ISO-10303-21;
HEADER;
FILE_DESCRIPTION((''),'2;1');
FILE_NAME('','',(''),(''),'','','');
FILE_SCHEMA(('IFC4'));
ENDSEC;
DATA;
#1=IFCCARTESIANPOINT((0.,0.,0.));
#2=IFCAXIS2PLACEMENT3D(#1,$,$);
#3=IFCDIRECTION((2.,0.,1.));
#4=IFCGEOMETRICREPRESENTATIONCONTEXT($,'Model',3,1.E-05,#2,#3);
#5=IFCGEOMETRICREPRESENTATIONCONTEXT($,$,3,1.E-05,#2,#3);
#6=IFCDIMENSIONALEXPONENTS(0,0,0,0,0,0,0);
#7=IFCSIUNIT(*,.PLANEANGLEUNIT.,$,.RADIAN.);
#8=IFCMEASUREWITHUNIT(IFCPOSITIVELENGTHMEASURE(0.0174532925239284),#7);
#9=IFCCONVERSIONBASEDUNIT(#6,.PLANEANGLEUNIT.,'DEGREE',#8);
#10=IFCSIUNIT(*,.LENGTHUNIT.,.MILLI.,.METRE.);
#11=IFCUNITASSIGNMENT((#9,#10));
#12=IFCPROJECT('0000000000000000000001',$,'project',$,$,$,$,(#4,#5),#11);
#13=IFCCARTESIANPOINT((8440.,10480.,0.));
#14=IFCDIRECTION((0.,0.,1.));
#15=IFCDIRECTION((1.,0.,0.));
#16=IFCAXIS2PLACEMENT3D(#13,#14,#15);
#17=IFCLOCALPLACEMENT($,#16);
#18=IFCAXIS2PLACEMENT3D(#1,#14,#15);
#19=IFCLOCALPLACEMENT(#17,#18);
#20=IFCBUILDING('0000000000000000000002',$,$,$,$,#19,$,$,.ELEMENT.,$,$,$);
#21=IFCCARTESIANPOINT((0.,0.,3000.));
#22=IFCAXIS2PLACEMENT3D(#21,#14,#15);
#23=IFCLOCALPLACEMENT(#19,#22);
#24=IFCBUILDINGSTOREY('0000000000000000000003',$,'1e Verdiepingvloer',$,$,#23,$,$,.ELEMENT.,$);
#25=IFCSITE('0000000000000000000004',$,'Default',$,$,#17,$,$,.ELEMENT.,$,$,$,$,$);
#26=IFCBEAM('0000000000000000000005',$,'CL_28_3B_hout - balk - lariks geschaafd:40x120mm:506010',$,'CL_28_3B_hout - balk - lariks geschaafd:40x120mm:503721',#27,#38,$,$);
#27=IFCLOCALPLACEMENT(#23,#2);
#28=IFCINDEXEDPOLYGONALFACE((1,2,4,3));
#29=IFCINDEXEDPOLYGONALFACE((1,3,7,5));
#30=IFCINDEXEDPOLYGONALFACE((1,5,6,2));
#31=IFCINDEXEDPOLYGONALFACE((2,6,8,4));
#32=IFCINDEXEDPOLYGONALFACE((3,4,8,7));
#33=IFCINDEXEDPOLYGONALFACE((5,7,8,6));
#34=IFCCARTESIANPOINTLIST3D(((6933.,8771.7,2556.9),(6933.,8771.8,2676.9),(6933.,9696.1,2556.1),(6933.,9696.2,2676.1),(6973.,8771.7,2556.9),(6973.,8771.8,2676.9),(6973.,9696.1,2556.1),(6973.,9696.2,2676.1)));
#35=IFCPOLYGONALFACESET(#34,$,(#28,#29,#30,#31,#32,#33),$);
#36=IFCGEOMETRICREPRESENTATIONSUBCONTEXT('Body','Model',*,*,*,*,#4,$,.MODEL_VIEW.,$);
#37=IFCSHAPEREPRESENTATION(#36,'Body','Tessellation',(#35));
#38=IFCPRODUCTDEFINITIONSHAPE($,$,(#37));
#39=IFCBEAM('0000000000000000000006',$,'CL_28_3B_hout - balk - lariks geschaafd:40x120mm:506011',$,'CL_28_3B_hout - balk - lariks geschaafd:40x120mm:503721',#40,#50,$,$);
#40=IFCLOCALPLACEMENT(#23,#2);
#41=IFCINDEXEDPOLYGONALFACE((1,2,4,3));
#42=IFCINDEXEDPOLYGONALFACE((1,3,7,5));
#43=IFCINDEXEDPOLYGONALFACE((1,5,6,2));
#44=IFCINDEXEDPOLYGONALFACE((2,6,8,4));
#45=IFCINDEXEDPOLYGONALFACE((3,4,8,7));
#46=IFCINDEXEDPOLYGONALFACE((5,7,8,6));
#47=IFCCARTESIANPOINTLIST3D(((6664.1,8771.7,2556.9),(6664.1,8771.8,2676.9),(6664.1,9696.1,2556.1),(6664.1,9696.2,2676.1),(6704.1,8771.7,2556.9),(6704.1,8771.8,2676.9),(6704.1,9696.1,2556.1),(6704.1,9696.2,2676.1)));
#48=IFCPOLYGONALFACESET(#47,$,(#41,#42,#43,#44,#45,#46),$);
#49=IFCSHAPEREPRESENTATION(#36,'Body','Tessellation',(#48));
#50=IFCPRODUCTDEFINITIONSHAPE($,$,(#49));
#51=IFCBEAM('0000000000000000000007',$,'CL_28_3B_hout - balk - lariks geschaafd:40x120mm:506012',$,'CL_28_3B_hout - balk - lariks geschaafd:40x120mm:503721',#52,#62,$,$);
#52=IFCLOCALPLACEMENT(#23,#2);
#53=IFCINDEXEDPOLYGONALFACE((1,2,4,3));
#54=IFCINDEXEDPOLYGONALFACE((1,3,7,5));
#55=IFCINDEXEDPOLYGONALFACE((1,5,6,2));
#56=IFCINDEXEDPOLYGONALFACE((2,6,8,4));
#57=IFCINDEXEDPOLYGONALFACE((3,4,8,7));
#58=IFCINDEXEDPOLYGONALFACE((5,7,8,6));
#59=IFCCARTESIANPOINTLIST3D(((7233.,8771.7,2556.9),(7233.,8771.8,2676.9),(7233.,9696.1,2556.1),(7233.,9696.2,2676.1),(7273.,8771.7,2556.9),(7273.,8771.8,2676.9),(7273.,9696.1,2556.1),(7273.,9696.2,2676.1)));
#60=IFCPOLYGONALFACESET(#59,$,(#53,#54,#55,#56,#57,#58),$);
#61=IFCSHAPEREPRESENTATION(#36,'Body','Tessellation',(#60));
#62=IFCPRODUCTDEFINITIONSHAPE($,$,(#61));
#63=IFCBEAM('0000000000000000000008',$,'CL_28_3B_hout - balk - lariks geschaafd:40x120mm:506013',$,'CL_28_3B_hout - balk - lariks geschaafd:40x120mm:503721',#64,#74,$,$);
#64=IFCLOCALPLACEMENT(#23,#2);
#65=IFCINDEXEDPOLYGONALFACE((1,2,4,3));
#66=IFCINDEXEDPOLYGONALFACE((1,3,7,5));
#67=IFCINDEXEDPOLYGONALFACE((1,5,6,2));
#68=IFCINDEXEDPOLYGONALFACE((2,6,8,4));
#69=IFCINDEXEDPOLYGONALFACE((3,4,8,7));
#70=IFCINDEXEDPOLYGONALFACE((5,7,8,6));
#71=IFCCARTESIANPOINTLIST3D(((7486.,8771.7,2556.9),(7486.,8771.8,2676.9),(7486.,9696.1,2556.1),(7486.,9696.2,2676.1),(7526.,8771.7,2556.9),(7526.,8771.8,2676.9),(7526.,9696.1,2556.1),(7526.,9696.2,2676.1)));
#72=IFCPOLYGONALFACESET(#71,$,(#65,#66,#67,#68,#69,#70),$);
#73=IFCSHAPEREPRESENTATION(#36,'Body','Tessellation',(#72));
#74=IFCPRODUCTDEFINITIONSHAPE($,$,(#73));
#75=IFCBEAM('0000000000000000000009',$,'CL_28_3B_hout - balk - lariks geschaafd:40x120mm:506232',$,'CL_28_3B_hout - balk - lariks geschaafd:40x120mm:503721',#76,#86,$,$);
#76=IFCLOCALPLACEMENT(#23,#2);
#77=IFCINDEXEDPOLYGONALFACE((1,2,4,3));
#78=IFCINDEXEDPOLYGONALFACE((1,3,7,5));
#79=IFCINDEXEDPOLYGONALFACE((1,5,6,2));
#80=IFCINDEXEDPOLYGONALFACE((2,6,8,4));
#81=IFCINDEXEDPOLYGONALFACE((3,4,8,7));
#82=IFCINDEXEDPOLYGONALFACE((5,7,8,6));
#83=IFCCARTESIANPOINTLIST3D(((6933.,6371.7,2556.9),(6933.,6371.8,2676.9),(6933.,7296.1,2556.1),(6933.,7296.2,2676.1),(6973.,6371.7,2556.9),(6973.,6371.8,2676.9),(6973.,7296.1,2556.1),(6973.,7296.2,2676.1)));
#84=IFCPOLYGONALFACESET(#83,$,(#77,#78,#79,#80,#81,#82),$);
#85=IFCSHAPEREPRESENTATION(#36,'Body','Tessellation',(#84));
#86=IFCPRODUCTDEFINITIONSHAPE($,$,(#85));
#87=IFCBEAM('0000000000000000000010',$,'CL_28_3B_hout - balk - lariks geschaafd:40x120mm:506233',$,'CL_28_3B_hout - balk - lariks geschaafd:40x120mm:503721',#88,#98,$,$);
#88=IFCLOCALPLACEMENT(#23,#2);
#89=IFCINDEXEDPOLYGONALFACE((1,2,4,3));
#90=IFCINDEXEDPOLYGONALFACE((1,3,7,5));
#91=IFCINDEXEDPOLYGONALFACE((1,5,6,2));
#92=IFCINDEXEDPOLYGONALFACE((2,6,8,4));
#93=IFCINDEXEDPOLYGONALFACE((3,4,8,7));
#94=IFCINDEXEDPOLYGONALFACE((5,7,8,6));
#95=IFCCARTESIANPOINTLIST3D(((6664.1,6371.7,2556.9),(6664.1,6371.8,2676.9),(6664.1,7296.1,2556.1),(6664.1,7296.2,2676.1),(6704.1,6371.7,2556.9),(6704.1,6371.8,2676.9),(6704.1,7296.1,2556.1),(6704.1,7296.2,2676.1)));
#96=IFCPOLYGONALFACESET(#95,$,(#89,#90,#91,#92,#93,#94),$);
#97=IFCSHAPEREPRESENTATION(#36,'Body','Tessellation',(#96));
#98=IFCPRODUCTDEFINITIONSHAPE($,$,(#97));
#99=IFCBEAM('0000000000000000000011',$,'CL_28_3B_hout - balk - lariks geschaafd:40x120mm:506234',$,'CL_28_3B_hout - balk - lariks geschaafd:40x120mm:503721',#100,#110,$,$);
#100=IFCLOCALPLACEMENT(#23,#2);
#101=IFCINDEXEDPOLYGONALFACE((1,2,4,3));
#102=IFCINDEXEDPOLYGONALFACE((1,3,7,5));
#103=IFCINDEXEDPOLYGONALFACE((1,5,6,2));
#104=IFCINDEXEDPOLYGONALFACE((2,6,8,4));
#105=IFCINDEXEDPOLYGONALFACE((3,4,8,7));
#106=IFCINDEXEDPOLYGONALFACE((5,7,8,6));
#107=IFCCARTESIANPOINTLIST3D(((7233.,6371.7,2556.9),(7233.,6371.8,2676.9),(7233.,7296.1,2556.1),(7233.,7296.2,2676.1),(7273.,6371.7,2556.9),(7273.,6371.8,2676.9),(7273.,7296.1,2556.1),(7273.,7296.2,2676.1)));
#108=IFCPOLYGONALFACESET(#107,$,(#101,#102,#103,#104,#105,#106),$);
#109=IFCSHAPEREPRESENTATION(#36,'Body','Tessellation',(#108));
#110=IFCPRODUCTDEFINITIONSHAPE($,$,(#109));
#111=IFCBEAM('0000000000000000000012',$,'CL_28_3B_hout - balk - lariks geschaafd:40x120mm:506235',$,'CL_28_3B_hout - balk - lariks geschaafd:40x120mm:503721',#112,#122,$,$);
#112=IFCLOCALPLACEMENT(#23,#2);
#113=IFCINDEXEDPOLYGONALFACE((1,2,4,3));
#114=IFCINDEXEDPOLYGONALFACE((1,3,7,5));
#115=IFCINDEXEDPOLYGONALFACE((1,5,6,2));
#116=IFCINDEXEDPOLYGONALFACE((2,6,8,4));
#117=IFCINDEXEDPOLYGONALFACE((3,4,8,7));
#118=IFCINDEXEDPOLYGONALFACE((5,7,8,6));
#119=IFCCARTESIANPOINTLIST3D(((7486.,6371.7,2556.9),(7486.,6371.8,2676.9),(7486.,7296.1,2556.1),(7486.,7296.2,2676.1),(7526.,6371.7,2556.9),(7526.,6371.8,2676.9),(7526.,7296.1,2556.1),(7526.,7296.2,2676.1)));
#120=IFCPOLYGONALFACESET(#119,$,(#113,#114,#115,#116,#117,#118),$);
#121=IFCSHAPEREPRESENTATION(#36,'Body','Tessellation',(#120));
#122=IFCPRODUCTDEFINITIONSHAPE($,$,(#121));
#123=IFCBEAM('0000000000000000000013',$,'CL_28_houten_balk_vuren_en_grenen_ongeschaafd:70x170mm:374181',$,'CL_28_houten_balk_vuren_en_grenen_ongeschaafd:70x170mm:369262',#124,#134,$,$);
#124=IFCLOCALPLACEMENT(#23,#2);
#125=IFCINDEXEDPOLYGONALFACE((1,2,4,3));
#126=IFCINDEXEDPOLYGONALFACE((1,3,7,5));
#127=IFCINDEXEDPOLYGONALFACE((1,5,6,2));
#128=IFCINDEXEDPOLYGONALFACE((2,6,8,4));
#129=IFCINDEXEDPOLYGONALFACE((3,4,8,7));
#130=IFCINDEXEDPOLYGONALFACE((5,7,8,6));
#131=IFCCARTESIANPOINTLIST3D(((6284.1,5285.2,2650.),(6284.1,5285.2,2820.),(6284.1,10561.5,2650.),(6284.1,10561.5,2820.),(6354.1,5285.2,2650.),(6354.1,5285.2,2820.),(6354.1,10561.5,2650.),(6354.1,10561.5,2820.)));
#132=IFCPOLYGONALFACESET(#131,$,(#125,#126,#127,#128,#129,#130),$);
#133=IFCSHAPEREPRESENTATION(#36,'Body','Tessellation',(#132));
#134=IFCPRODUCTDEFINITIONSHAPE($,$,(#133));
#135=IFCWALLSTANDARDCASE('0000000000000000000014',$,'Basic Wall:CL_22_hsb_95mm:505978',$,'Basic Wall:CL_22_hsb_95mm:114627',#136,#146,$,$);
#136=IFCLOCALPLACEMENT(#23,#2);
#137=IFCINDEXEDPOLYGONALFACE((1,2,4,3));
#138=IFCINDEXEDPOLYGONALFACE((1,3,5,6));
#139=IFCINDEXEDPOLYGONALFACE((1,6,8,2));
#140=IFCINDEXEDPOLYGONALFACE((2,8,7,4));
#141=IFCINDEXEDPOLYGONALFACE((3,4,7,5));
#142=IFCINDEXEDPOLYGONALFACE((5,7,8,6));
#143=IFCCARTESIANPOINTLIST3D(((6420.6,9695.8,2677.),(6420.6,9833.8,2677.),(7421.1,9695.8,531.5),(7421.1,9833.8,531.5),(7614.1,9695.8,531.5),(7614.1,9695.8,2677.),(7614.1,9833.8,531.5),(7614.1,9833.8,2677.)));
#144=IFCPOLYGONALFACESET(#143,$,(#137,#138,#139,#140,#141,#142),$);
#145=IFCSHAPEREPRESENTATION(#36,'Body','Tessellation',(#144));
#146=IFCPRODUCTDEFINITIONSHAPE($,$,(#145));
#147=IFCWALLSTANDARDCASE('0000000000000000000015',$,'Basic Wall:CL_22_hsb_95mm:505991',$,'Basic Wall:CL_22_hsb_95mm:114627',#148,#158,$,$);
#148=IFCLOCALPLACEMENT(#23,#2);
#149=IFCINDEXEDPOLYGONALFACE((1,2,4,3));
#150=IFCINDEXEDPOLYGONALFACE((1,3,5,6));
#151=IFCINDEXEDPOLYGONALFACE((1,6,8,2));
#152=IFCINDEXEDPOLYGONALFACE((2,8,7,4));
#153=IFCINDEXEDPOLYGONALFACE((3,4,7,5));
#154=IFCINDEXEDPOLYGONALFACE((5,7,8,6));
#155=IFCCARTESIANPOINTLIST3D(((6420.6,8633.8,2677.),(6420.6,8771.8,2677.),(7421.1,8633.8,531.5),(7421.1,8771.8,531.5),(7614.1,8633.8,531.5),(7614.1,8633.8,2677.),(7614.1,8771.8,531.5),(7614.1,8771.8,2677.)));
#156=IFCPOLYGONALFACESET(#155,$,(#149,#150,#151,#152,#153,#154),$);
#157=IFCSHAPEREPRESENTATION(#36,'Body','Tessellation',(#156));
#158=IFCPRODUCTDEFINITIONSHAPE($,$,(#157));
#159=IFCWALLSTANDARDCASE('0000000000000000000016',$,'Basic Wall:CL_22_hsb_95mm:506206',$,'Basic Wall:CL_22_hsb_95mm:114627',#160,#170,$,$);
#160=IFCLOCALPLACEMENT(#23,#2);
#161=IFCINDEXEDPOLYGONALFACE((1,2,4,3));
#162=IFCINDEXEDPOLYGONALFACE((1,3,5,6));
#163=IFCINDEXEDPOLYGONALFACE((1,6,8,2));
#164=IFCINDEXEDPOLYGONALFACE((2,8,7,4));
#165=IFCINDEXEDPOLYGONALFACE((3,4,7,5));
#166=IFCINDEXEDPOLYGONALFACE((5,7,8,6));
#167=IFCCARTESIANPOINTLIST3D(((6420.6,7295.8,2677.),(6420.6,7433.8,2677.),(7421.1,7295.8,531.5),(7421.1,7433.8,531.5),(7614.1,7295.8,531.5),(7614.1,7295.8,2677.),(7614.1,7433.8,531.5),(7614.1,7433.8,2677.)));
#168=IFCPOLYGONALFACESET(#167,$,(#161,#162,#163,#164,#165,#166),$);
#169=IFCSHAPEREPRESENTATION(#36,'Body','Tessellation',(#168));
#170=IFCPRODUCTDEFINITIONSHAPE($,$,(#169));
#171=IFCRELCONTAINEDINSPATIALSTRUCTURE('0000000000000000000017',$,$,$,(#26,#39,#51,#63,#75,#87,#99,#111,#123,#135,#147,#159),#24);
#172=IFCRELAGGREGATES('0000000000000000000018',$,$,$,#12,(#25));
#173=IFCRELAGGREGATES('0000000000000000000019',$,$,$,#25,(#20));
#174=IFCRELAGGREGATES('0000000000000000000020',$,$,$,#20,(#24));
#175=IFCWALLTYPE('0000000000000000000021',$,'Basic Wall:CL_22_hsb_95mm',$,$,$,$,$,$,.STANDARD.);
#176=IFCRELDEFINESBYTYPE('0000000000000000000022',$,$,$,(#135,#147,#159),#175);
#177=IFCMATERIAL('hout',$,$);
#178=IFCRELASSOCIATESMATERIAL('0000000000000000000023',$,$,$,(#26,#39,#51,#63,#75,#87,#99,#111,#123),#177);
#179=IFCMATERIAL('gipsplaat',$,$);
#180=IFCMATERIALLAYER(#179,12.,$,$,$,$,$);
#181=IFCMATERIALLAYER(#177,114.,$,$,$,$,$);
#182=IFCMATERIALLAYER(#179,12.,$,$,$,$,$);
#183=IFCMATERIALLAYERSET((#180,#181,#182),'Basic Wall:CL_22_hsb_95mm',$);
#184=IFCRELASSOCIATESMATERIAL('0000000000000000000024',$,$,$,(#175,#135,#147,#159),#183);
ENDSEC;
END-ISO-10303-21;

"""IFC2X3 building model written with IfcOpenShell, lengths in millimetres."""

from ifc_helpers import new_model, entity, si_unit, converted_unit, direction, frame, frame_2d, origin, origin_with_axes, place, context, subcontext, project, spatial, rectangle, extrude, clip, halfspace, source, transform, mapped, material, layer, layer_set, layer_usage, type_object, element, save


model = new_model("IFC2X3")

# Units and contexts
model_context = context("Model", 3, precision=1e-05, world=origin(), true_north=direction((2.0, 0.0, 1.0)))
context_of_model = context(None, 3, precision=1e-05, world=origin(), true_north=direction((2.0, 0.0, 1.0)))
body_context = subcontext(model_context, "Body", "Model", "MODEL_VIEW")
ifc_project = project(units=[converted_unit("PLANEANGLEUNIT", "DEGREE", entity("IfcPositiveLengthMeasure", 0.0174532925239284), si_unit("PLANEANGLEUNIT", "RADIAN"), dimensions=[0, 0, 0, 0, 0, 0, 0]), si_unit("LENGTHUNIT", "METRE", prefix="MILLI")], contexts=[model_context, context_of_model])

# Site, building, storey
site_placement = place(None, frame((8440.0, 10480.0, 0.0), z_axis=(0.0, 0.0, 1.0), x_axis=(1.0, 0.0, 0.0)))
site = spatial("IfcSite", under=ifc_project, at=site_placement, Name="Default", CompositionType="ELEMENT")
building_placement = place(site_placement, origin_with_axes())
building = spatial("IfcBuilding", under=site, at=building_placement, CompositionType="ELEMENT")
storey_placement = place(building_placement, frame((0.0, 0.0, 3000.0), z_axis=(0.0, 0.0, 1.0), x_axis=(1.0, 0.0, 0.0)))
storey = spatial("IfcBuildingStorey", under=building, at=storey_placement, Name="1e Verdiepingvloer", CompositionType="ELEMENT")

# Beams
ifc_material_1 = material(Name="hout")
shared_shape_1 = source(origin(), body_context, "Body", "SweptSolid", [
    extrude(rectangle(XDim=120.0, YDim=40.0, at=frame_2d((0.0, 0.0), x_axis=(1.0, 0.0))), frame((68.6, 0.0, -60.0), z_axis=(1.0, 0.0, 0.0), x_axis=(0.0, 0.0, -1.0)), (0.0, 0.0, 1.0), 924.4),
])
for number, where, z_axis, x_axis, name in (
    (1, (6953.0, 9764.8, 2676.0), (0.0, 0.000942, 1.0), (0.0, -1.0, 0.000942), "CL_28_3B_hout - balk - lariks geschaafd:40x120mm:506010"),
    (2, (6684.1, 9764.8, 2676.0), (0.0, 0.000942, 1.0), (0.0, -1.0, 0.000942), "CL_28_3B_hout - balk - lariks geschaafd:40x120mm:506011"),
    (3, (7253.0, 9764.8, 2676.0), (0.0, 0.000942, 1.0), (0.0, -1.0, 0.000942), "CL_28_3B_hout - balk - lariks geschaafd:40x120mm:506012"),
    (4, (7506.0, 9764.8, 2676.0), (0.0, 0.000942, 1.0), (0.0, -1.0, 0.000942), "CL_28_3B_hout - balk - lariks geschaafd:40x120mm:506013"),
    (5, (6953.0, 7364.8, 2676.0), (0.0, 0.000942, 1.0), (0.0, -1.0, 0.000942), "CL_28_3B_hout - balk - lariks geschaafd:40x120mm:506232"),
    (6, (6684.1, 7364.8, 2676.0), (0.0, 0.000942, 1.0), (0.0, -1.0, 0.000942), "CL_28_3B_hout - balk - lariks geschaafd:40x120mm:506233"),
    (7, (7253.0, 7364.8, 2676.0), (0.0, 0.000942, 1.0), (0.0, -1.0, 0.000942), "CL_28_3B_hout - balk - lariks geschaafd:40x120mm:506234"),
    (8, (7506.0, 7364.8, 2676.0), (0.0, 0.000942, 1.0), (0.0, -1.0, 0.000942), "CL_28_3B_hout - balk - lariks geschaafd:40x120mm:506235"),
):
    element("IfcBeam", number, at=place(storey_placement, frame(where, z_axis=z_axis, x_axis=x_axis)), inside=storey, material=ifc_material_1, Name=name, ObjectType="CL_28_3B_hout - balk - lariks geschaafd:40x120mm:503721", context=body_context, shape_type="MappedRepresentation", body=[
        mapped(shared_shape_1, transform((0.0, 0.0, 0.0))),
    ])
beam_1_placement = place(storey_placement, frame((6319.1, 10641.8, 2820.0), z_axis=(0.0, 0.0, 1.0), x_axis=(0.0, -1.0, 0.0)))
element("IfcBeam", 9, at=beam_1_placement, inside=storey, material=ifc_material_1, Name="CL_28_houten_balk_vuren_en_grenen_ongeschaafd:70x170mm:374181", ObjectType="CL_28_houten_balk_vuren_en_grenen_ongeschaafd:70x170mm:369262", context=body_context, shape_type="SweptSolid", body=[
    extrude(rectangle(XDim=170.0, YDim=70.0, at=frame_2d((0.0, 0.0), x_axis=(1.0, 0.0))), frame((80.3, 0.0, -85.0), z_axis=(1.0, 0.0, 0.0), x_axis=(0.0, 0.0, -1.0)), (0.0, 0.0, 1.0), 5276.3),
])

# Walls
ifc_material_2 = material(Name="gipsplaat")
ifc_layer_1 = layer(ifc_material_2, 12.0)
ifc_layer_2 = layer(ifc_material_1, 114.0)
ifc_layer_3 = layer(ifc_material_2, 12.0)
ifc_layer_set = layer_set([ifc_layer_1, ifc_layer_2, ifc_layer_3], Name="Basic Wall:CL_22_hsb_95mm")
ifc_layer_usage_1 = layer_usage(ifc_layer_set, "AXIS2", "NEGATIVE", 69.0)
wall_type = type_object("IfcWallType", Name="Basic Wall:CL_22_hsb_95mm", PredefinedType="STANDARD", material=ifc_layer_set)
shared_shape_2 = source(origin(), body_context, "Body", "Clipping", [
    clip(clip(extrude(rectangle(XDim=1193.5, YDim=138.0, at=frame_2d((596.7, 0.0), x_axis=(-1.0, 0.0))), origin(), (0.0, 0.0, 1.0), 2677.0), halfspace(frame((1000.5, -69.0, 531.5), z_axis=(-0.906308, 0.0, -0.422618), x_axis=(0.0, 1.0, 0.0)), False)), halfspace(frame((1193.5, -69.0, 531.5), z_axis=(0.0, 0.0, -1.0), x_axis=(0.0, 1.0, 0.0)), False)),
])
wall_1_placement = place(storey_placement, frame((6420.6, 9764.8, 0.0), z_axis=(0.0, 0.0, 1.0), x_axis=(1.0, 0.0, 0.0)))
element("IfcWallStandardCase", 10, at=wall_1_placement, inside=storey, type_object=wall_type, material=ifc_layer_usage_1, Name="Basic Wall:CL_22_hsb_95mm:505978", ObjectType="Basic Wall:CL_22_hsb_95mm:114627", context=body_context, shape_type="MappedRepresentation", body=[
    mapped(shared_shape_2, transform((0.0, 0.0, 0.0))),
])
ifc_layer_usage_2 = layer_usage(ifc_layer_set, "AXIS2", "NEGATIVE", 69.0)
wall_2_placement = place(storey_placement, frame((6420.6, 8702.8, 0.0), z_axis=(0.0, 0.0, 1.0), x_axis=(1.0, 0.0, 0.0)))
element("IfcWallStandardCase", 11, at=wall_2_placement, inside=storey, type_object=wall_type, material=ifc_layer_usage_2, Name="Basic Wall:CL_22_hsb_95mm:505991", ObjectType="Basic Wall:CL_22_hsb_95mm:114627", context=body_context, shape_type="MappedRepresentation", body=[
    mapped(shared_shape_2, transform((0.0, 0.0, 0.0))),
])
ifc_layer_usage_3 = layer_usage(ifc_layer_set, "AXIS2", "NEGATIVE", 69.0)
wall_3_placement = place(storey_placement, frame((6420.6, 7364.8, 0.0), z_axis=(0.0, 0.0, 1.0), x_axis=(1.0, 0.0, 0.0)))
element("IfcWallStandardCase", 12, at=wall_3_placement, inside=storey, type_object=wall_type, material=ifc_layer_usage_3, Name="Basic Wall:CL_22_hsb_95mm:506206", ObjectType="Basic Wall:CL_22_hsb_95mm:114627", context=body_context, shape_type="MappedRepresentation", body=[
    mapped(shared_shape_2, transform((0.0, 0.0, 0.0))),
])

save(model, "model.ifc")
